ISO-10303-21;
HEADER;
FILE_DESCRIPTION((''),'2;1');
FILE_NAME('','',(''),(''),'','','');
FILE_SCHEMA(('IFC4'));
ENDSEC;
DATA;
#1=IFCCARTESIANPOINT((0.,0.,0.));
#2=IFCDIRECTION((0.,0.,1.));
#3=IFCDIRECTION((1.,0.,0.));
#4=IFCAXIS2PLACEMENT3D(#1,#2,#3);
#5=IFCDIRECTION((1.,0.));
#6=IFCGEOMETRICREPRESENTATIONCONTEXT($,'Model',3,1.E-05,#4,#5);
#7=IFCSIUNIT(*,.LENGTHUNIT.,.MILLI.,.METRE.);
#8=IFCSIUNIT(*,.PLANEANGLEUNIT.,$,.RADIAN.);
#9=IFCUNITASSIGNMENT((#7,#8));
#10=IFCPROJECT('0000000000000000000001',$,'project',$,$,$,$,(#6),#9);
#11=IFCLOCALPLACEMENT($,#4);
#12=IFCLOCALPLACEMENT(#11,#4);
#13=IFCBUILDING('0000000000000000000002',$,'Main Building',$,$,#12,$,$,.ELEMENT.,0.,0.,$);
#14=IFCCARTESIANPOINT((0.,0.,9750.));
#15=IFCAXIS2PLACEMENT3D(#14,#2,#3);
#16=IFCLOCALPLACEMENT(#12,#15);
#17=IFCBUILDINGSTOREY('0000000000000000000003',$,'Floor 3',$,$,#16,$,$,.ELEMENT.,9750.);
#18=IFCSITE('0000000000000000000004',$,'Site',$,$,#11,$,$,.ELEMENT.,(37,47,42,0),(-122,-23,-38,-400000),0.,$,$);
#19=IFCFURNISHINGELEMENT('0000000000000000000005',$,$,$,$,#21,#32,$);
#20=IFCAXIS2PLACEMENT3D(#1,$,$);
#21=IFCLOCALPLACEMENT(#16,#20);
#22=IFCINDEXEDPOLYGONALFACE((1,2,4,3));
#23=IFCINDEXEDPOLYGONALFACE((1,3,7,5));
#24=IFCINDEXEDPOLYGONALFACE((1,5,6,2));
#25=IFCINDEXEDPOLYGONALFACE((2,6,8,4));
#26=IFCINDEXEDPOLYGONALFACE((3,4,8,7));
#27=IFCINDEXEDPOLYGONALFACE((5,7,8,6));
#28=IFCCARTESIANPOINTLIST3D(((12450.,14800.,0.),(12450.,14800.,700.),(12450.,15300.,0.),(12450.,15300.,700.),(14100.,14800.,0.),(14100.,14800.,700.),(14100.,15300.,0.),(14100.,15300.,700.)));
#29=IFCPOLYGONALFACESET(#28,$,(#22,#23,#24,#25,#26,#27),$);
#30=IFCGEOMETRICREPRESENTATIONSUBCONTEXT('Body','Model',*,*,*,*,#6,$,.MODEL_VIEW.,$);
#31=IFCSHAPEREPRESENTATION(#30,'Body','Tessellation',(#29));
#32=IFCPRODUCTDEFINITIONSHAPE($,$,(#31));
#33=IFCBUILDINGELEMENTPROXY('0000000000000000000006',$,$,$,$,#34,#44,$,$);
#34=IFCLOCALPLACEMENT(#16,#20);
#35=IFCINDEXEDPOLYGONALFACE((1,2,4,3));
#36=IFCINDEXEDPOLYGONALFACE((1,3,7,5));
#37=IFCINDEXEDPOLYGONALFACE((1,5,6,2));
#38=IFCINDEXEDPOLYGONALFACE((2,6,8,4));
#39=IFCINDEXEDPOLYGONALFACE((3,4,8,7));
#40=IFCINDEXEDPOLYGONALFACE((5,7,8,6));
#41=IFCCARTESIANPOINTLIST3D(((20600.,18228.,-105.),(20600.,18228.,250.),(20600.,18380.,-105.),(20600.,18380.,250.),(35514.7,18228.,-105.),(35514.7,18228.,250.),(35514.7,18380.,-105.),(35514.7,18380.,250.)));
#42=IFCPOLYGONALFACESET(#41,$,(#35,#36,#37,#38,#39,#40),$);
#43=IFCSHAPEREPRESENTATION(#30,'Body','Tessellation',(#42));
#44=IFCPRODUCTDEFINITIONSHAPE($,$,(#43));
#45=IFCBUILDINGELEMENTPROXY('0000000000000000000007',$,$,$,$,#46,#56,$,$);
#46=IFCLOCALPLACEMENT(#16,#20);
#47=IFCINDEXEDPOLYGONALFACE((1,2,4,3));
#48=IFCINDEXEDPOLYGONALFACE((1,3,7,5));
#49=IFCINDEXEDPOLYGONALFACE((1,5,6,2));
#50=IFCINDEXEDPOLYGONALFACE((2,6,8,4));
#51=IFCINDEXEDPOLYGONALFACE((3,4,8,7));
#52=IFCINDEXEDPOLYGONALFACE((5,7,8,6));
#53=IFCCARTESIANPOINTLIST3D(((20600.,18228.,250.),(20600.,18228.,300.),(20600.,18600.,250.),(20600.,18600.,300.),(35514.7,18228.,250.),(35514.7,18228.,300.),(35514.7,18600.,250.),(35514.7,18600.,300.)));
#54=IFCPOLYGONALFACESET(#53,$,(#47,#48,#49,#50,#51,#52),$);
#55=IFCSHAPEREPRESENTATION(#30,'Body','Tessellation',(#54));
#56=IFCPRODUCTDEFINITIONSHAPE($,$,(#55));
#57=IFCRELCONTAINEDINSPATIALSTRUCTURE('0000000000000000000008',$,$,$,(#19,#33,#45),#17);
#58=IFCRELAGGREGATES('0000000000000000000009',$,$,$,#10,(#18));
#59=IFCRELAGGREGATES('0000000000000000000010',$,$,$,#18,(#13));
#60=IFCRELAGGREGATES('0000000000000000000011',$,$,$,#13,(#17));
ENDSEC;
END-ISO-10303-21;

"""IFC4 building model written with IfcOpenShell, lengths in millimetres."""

from ifc_helpers import new_model, si_unit, direction, frame, origin_with_axes, origin_2d_with_axis, place, context, subcontext, project, spatial, rectangle, extrude, element, save


model = new_model("IFC4")

# Units and contexts
model_context = context("Model", 3, precision=1e-05, world=origin_with_axes(), true_north=direction((1.0, 0.0)))
body_context = subcontext(model_context, "Body", "Model", "MODEL_VIEW")
ifc_project = project(units=[si_unit("LENGTHUNIT", "METRE", prefix="MILLI"), si_unit("PLANEANGLEUNIT", "RADIAN")], contexts=[model_context])

# Site, building, storey
site_placement = place(None, origin_with_axes())
site = spatial("IfcSite", under=ifc_project, at=site_placement, Name="Site", CompositionType="ELEMENT", RefLatitude=(37, 47, 42, 0), RefLongitude=(-122, -23, -38, -400000), RefElevation=0.0)
building_placement = place(site_placement, origin_with_axes())
building = spatial("IfcBuilding", under=site, at=building_placement, Name="Main Building", CompositionType="ELEMENT", ElevationOfRefHeight=0.0, ElevationOfTerrain=0.0)
storey_placement = place(building_placement, frame((0.0, 0.0, 9750.0), z_axis=(0.0, 0.0, 1.0), x_axis=(1.0, 0.0, 0.0)))
storey = spatial("IfcBuildingStorey", under=building, at=storey_placement, Name="Floor 3", CompositionType="ELEMENT", Elevation=9750.0)

# Furnishing element
furnishing_placement = place(storey_placement, frame((12450.0, 14800.0, 0.0), z_axis=(0.0, 0.0, 1.0), x_axis=(1.0, 0.0, 0.0)))
element("IfcFurnishingElement", 1, at=furnishing_placement, inside=storey, context=body_context, shape_type="SweptSolid", body=[
    extrude(rectangle(XDim=1650.0, YDim=500.0, at=origin_2d_with_axis()), frame((825.0, 250.0, 0.0), z_axis=(0.0, 0.0, 1.0), x_axis=(1.0, 0.0, 0.0)), (0.0, 0.0, 1.0), 700.0),
])

# Building element proxies
proxy_1_placement = place(storey_placement, frame((20600.0, 18228.0, -105.0), z_axis=(0.0, 0.0, 1.0), x_axis=(1.0, 0.0, 0.0)))
element("IfcBuildingElementProxy", 2, at=proxy_1_placement, inside=storey, context=body_context, shape_type="SweptSolid", body=[
    extrude(rectangle(XDim=14914.7, YDim=152.0, at=origin_2d_with_axis()), frame((7457.3, 76.0, 0.0), z_axis=(0.0, 0.0, 1.0), x_axis=(1.0, 0.0, 0.0)), (0.0, 0.0, 1.0), 355.0),
])
proxy_2_placement = place(storey_placement, frame((20600.0, 18228.0, 250.0), z_axis=(0.0, 0.0, 1.0), x_axis=(1.0, 0.0, 0.0)))
element("IfcBuildingElementProxy", 3, at=proxy_2_placement, inside=storey, context=body_context, shape_type="SweptSolid", body=[
    extrude(rectangle(XDim=14914.7, YDim=372.0, at=origin_2d_with_axis()), frame((7457.3, 186.0, 0.0), z_axis=(0.0, 0.0, 1.0), x_axis=(1.0, 0.0, 0.0)), (0.0, 0.0, 1.0), 50.0),
])

save(model, "model.ifc")
